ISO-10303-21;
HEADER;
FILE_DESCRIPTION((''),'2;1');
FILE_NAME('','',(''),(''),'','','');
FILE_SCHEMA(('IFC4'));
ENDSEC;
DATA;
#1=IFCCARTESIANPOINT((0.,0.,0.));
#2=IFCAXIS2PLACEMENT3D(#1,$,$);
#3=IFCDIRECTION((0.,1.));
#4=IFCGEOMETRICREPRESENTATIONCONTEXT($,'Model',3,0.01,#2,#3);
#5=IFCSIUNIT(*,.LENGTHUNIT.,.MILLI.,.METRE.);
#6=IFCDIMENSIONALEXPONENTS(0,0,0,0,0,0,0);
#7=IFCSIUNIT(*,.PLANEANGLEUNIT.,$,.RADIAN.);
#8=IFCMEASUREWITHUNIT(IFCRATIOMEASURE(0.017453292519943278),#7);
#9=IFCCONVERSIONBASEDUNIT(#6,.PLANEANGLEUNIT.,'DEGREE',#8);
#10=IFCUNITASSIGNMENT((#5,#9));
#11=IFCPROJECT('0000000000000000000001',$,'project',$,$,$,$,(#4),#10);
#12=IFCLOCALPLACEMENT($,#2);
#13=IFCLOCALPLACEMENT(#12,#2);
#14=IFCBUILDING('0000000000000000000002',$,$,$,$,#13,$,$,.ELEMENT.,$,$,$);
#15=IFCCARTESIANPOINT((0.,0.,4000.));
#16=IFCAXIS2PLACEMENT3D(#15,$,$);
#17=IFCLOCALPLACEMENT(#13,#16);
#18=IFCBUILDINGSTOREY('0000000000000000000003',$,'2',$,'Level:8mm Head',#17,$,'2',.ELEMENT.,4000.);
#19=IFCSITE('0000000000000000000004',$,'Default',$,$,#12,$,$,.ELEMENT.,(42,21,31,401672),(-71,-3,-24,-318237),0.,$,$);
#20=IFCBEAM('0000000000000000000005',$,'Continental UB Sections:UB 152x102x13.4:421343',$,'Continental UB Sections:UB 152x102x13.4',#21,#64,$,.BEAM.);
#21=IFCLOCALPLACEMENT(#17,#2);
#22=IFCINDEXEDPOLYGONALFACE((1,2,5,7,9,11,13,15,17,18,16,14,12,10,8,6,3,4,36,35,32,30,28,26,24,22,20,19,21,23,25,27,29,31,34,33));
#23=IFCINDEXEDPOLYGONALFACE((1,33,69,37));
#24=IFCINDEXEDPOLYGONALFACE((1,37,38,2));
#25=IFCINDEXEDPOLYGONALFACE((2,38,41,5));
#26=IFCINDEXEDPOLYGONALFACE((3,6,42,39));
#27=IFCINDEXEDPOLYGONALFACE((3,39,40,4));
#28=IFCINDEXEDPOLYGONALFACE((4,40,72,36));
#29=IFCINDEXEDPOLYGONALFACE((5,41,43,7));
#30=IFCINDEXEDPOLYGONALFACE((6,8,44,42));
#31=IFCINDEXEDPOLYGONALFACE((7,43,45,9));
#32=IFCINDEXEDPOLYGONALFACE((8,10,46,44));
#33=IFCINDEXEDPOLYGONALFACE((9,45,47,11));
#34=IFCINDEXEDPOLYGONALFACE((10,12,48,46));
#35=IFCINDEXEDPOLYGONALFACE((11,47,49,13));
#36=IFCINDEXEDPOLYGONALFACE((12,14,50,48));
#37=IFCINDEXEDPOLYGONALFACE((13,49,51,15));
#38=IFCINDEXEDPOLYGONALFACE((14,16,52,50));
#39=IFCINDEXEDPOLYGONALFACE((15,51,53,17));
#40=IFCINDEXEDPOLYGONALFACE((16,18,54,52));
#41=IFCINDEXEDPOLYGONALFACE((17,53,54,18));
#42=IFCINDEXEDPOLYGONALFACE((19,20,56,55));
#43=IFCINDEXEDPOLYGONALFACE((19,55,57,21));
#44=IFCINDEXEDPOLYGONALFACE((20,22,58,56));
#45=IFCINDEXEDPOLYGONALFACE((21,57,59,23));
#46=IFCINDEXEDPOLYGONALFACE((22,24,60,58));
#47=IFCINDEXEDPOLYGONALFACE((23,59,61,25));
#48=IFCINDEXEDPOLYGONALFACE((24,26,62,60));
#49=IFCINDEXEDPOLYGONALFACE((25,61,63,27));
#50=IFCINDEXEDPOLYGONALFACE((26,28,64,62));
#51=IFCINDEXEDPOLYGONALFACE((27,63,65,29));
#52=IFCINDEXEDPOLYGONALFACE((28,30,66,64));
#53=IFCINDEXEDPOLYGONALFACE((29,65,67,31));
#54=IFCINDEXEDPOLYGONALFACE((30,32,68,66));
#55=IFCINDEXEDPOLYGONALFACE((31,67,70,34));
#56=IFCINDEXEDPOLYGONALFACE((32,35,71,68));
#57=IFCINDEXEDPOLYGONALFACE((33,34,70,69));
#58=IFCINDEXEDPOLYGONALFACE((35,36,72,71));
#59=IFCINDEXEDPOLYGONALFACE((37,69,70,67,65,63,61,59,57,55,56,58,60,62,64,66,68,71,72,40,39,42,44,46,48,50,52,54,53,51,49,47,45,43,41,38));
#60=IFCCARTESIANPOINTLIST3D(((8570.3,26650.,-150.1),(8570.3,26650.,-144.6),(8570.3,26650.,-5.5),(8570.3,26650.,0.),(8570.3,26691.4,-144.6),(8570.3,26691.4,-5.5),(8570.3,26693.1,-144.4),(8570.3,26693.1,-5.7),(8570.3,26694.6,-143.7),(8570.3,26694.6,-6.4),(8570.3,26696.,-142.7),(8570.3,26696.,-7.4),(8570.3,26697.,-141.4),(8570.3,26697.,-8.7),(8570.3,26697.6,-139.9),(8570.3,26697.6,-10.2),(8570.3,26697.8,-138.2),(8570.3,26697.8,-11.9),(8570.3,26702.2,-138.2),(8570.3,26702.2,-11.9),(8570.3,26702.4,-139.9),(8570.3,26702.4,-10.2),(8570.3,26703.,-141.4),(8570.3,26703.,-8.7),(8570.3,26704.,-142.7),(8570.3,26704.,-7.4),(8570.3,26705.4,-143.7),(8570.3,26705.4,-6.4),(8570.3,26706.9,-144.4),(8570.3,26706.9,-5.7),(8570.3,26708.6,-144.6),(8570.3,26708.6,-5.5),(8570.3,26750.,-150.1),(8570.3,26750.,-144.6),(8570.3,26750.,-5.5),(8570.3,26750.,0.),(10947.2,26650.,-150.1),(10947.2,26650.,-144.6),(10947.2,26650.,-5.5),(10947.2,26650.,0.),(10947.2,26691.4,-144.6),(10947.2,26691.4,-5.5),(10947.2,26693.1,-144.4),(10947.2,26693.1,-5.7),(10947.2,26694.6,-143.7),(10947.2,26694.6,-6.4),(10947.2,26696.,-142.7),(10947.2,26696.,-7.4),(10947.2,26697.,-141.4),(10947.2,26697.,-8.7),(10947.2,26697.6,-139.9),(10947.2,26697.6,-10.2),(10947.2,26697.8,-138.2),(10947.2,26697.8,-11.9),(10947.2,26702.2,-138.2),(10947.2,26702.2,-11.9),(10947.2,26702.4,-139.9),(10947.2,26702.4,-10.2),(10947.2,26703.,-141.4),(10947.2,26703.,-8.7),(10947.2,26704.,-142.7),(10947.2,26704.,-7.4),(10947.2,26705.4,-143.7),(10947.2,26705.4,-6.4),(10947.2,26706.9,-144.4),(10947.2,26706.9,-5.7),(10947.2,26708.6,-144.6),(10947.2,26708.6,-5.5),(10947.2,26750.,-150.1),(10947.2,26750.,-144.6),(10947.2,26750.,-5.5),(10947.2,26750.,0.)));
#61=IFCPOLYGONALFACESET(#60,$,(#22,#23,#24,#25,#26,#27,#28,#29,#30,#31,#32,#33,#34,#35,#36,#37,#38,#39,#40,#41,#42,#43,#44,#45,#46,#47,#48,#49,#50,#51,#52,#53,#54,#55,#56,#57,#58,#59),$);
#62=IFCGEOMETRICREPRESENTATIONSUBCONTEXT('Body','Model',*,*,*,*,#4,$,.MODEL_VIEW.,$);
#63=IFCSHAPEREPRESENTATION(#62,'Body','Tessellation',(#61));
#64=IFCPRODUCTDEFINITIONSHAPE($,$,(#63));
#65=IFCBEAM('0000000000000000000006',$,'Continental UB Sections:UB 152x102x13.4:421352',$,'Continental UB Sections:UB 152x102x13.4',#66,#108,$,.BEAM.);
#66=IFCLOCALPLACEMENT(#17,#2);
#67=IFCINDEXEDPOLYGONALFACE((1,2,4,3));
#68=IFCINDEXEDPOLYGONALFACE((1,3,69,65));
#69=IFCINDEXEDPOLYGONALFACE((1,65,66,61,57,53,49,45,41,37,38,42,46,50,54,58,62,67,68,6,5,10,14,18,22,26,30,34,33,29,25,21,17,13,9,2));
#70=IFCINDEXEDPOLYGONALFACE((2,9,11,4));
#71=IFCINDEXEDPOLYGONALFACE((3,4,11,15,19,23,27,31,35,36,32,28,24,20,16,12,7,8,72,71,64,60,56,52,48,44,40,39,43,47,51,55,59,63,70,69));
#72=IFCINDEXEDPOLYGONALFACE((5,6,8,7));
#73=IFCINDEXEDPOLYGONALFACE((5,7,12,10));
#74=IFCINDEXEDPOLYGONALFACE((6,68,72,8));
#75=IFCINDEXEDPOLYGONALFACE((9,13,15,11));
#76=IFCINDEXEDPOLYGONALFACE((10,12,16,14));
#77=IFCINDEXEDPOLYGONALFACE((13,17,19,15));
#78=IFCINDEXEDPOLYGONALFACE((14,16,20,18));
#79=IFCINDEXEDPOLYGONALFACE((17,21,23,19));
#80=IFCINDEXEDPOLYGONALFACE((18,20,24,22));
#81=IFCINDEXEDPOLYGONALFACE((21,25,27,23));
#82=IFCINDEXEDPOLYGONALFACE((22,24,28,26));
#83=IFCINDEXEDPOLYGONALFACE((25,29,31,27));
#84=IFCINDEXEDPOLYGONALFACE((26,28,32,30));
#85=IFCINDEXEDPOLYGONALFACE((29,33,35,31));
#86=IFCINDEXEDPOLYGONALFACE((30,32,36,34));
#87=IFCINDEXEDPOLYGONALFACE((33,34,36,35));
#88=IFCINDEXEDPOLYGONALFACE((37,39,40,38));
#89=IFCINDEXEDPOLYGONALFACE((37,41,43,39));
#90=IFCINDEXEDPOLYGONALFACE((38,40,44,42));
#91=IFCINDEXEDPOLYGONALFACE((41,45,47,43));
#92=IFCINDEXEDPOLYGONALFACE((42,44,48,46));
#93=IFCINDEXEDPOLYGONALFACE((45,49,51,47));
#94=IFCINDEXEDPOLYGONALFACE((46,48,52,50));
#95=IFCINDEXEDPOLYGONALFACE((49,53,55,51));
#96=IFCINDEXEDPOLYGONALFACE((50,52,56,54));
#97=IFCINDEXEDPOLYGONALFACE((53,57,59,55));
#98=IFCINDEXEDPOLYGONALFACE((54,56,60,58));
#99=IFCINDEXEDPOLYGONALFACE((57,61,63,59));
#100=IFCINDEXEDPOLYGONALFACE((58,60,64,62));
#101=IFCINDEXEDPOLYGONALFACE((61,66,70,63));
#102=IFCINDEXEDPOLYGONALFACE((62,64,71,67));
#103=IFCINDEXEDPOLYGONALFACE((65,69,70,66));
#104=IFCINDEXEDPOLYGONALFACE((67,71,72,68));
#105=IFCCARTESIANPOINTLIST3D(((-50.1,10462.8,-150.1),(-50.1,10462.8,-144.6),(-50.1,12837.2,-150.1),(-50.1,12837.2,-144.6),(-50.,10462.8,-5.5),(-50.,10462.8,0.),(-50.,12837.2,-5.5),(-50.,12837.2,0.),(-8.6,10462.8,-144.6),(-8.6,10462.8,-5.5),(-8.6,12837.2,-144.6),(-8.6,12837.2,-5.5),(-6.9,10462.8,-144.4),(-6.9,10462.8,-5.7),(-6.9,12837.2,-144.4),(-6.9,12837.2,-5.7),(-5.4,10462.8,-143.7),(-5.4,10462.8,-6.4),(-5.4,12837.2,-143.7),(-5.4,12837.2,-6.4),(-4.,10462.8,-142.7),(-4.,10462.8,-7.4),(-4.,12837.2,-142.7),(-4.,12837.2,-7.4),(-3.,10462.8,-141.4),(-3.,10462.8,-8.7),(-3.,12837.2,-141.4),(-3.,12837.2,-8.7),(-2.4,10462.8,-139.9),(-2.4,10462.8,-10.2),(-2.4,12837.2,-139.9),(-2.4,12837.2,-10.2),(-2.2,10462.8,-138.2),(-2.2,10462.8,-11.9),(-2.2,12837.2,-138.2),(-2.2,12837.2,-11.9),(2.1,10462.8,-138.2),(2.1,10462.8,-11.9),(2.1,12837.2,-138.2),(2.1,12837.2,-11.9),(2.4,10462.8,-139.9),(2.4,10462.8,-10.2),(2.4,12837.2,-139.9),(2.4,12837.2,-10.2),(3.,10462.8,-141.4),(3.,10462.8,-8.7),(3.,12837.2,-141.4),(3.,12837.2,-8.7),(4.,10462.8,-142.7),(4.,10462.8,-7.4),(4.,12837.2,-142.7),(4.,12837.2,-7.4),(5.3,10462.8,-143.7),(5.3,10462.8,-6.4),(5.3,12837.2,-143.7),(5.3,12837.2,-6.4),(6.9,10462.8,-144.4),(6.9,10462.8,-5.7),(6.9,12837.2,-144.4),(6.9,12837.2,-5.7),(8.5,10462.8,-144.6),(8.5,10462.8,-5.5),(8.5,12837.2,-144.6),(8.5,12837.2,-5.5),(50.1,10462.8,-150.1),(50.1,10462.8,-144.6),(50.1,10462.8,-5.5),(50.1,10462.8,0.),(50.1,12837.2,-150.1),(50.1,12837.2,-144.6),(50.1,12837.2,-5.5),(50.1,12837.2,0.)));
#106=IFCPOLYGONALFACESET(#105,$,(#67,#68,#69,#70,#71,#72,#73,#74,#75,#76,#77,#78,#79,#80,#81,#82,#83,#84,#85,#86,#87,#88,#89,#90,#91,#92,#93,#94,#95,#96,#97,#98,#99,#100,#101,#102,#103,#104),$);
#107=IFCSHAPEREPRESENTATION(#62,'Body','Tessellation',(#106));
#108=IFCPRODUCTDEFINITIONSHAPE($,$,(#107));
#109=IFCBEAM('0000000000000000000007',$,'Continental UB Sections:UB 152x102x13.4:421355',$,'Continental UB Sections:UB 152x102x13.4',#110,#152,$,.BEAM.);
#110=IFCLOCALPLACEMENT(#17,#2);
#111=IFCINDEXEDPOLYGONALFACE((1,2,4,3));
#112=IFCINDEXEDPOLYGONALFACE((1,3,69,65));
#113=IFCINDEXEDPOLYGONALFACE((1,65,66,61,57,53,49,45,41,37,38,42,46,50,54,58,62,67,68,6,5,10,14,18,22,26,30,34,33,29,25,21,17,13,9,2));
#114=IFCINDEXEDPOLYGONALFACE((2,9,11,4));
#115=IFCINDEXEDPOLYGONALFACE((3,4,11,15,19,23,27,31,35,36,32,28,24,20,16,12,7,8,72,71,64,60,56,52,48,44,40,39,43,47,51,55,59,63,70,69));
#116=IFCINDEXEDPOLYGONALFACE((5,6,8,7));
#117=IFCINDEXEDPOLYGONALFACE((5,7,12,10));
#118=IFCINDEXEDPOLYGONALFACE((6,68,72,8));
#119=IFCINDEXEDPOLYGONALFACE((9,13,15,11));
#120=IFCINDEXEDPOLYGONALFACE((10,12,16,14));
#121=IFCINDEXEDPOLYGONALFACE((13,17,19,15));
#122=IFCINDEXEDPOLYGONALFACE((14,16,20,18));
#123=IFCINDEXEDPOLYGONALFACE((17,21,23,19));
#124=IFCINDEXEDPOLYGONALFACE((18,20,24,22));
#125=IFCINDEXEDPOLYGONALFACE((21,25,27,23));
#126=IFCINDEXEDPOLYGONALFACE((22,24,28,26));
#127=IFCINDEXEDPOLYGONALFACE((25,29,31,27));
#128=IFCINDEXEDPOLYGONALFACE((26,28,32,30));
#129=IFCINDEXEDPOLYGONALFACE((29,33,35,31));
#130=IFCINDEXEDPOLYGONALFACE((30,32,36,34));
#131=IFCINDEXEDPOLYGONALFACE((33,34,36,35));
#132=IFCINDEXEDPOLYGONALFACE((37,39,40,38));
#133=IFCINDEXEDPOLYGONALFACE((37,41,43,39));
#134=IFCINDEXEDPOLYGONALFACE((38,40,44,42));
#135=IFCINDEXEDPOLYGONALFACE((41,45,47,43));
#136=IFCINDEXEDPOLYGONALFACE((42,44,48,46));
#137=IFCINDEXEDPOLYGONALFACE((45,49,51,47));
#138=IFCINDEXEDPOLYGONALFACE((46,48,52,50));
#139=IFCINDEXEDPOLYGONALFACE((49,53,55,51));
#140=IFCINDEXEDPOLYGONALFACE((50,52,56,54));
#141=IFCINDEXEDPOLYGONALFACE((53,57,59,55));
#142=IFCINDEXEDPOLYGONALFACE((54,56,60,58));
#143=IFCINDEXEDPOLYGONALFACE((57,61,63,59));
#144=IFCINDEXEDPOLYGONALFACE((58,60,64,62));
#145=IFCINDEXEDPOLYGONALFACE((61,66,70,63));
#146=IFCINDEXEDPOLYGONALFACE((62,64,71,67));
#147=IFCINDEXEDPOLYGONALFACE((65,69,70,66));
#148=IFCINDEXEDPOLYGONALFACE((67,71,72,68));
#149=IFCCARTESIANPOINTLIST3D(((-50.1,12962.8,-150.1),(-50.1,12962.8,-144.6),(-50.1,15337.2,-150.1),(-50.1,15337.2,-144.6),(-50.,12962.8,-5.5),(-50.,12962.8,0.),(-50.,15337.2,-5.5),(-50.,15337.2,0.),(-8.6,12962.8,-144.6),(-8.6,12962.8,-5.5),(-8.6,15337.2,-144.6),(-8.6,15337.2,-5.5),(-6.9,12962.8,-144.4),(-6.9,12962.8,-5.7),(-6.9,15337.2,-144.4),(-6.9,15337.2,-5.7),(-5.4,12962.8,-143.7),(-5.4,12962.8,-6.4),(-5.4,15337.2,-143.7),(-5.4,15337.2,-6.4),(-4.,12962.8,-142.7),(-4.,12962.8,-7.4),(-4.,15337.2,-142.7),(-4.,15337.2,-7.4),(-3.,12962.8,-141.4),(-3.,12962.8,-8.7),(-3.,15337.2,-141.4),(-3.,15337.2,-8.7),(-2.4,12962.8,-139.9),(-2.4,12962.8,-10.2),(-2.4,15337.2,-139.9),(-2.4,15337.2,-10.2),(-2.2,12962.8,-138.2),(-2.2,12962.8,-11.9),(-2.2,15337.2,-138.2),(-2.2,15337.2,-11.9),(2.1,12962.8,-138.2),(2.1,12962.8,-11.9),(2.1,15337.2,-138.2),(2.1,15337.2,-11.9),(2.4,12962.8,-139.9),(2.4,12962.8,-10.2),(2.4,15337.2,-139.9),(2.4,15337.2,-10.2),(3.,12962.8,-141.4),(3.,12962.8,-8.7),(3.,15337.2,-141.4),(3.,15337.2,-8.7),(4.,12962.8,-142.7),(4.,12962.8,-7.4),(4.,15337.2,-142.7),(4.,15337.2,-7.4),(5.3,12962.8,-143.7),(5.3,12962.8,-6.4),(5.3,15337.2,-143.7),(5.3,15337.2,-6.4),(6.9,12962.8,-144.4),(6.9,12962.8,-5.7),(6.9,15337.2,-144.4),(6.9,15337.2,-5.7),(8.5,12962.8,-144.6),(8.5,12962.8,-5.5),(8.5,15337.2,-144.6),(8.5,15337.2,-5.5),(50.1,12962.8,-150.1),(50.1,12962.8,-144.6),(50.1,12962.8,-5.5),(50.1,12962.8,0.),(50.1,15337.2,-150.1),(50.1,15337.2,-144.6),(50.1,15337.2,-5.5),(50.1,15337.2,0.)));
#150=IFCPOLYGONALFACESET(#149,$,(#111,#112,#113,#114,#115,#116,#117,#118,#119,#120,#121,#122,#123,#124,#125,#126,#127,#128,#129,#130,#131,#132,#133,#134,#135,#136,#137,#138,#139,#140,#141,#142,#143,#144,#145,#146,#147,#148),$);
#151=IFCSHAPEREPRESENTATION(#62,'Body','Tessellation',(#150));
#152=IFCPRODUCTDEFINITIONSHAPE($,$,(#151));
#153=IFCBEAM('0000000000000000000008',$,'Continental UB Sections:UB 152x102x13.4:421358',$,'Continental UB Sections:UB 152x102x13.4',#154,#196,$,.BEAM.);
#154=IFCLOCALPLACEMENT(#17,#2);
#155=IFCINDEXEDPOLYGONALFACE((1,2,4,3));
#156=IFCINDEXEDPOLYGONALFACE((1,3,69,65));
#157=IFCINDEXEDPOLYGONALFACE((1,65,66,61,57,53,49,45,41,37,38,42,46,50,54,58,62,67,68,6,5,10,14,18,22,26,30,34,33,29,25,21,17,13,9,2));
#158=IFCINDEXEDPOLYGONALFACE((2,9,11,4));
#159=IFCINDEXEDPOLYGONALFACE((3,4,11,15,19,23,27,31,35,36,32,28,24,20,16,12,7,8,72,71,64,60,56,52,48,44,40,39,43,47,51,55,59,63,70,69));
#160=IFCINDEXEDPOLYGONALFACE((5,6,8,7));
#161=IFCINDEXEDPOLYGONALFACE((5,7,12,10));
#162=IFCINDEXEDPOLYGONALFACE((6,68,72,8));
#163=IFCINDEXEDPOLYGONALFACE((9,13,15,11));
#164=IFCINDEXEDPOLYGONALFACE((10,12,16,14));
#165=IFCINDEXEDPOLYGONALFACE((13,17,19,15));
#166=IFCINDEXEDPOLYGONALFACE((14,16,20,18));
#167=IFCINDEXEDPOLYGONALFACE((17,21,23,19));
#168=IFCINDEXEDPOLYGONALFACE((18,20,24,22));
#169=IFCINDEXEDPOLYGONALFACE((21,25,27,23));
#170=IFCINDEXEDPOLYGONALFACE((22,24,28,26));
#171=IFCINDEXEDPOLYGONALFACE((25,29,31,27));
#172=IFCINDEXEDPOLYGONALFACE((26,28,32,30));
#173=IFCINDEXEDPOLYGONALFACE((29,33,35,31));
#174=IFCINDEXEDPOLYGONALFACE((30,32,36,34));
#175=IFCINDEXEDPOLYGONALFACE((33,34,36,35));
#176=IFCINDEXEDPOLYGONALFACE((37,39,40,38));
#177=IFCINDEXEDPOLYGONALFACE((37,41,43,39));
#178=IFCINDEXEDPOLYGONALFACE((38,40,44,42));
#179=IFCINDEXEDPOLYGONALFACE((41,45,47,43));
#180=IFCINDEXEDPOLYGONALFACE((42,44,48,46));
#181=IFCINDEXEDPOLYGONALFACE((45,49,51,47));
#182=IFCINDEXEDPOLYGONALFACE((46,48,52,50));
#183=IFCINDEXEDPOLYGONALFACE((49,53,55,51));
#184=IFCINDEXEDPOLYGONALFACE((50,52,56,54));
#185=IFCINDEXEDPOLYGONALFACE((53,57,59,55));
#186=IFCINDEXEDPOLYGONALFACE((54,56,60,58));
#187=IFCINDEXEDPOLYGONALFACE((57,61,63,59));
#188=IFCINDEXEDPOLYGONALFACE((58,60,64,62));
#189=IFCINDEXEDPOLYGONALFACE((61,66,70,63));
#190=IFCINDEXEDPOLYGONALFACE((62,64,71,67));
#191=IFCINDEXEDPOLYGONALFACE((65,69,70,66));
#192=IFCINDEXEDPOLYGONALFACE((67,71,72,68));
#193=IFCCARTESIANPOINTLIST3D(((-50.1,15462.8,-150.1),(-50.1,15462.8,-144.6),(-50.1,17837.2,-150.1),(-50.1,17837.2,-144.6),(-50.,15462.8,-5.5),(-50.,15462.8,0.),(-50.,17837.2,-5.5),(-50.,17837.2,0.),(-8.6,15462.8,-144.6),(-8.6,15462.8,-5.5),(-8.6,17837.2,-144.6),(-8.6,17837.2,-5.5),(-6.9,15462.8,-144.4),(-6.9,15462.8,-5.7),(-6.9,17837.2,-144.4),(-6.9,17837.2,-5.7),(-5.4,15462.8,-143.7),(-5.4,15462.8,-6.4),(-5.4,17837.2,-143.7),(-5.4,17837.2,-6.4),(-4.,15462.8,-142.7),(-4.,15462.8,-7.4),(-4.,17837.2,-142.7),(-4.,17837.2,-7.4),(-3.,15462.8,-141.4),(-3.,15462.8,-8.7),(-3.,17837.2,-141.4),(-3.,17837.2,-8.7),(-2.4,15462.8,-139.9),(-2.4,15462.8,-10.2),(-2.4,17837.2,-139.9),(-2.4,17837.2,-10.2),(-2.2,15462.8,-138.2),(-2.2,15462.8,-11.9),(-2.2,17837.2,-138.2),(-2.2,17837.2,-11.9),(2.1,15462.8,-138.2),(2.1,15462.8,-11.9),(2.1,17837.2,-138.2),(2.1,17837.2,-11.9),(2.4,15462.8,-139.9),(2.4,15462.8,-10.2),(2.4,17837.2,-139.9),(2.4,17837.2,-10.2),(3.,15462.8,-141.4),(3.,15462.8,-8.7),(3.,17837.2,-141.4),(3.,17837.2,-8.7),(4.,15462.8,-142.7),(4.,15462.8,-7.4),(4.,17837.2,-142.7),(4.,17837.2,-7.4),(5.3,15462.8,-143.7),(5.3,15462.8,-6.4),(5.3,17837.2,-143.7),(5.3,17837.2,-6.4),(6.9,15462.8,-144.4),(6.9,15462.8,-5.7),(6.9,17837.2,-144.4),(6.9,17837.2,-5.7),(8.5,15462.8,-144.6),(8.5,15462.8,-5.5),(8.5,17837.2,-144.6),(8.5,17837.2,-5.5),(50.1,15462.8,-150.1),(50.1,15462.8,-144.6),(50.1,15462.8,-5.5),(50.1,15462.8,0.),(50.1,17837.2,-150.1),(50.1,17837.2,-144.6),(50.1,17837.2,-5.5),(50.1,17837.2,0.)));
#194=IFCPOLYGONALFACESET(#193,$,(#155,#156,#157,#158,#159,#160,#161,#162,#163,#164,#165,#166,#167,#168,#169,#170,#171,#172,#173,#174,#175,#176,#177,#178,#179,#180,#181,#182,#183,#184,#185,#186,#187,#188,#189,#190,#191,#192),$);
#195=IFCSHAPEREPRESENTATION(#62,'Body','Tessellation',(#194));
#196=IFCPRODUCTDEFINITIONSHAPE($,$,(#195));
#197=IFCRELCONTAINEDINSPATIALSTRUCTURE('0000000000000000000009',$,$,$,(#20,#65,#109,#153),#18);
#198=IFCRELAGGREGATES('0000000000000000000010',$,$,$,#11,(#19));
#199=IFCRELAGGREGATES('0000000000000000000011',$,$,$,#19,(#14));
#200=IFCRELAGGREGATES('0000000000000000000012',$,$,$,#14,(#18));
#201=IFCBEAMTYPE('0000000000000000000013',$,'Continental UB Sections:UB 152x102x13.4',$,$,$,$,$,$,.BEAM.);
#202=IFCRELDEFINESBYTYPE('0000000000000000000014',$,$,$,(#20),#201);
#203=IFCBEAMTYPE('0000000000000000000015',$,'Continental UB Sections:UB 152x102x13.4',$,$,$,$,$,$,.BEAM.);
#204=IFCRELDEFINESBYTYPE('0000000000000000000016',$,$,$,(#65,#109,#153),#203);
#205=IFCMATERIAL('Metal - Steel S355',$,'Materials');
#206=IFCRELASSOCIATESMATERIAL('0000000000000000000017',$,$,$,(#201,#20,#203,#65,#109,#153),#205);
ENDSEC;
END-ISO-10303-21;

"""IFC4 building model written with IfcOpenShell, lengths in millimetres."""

from ifc_helpers import new_model, entity, si_unit, converted_unit, direction, frame, origin, place, context, subcontext, project, spatial, line, arc, indexed_curve, outline, extrude, source, transform, mapped, material, type_object, type_shapes, element, save


model = new_model("IFC4")

# Units and contexts
model_context = context("Model", 3, precision=0.01, world=origin(), true_north=direction((0.0, 1.0)))
body_context = subcontext(model_context, "Body", "Model", "MODEL_VIEW")
ifc_project = project(units=[si_unit("LENGTHUNIT", "METRE", prefix="MILLI"), converted_unit("PLANEANGLEUNIT", "DEGREE", entity("IfcRatioMeasure", 0.017453292519943278), si_unit("PLANEANGLEUNIT", "RADIAN"), dimensions=[0, 0, 0, 0, 0, 0, 0])], contexts=[model_context])

# Site, building, storey
site_placement = place(None, origin())
site = spatial("IfcSite", under=ifc_project, at=site_placement, Name="Default", CompositionType="ELEMENT", RefLatitude=(42, 21, 31, 401672), RefLongitude=(-71, -3, -24, -318237), RefElevation=0.0)
building_placement = place(site_placement, origin())
building = spatial("IfcBuilding", under=site, at=building_placement, CompositionType="ELEMENT")
storey_placement = place(building_placement, frame((0.0, 0.0, 4000.0)))
storey = spatial("IfcBuildingStorey", under=building, at=storey_placement, Name="2", ObjectType="Level:8mm Head", LongName="2", CompositionType="ELEMENT", Elevation=4000.0)

# Beams
ifc_material_1 = material(Name="Metal - Steel S355", Category="Materials")
beam_type_1 = type_object("IfcBeamType", Name="Continental UB Sections:UB 152x102x13.4", PredefinedType="BEAM", material=ifc_material_1)
shared_shape_1 = source(origin(), body_context, "Body", "SweptSolid", [
    extrude(outline(indexed_curve([(-75.0, -50.1), (-69.6, -50.1), (-69.6, -8.5), (-67.7, -4.0), (-63.2, -2.1), (63.1, -2.1), (67.7, -4.0), (69.5, -8.5), (69.5, -50.1), (75.1, -50.1), (75.1, 50.1), (69.5, 50.1), (69.5, 8.6), (67.7, 4.0), (63.1, 2.2), (-63.2, 2.2), (-67.7, 4.0), (-69.6, 8.6), (-69.6, 50.0), (-75.0, 50.0)], segments=[line(1, 2, 3), arc(3, 4, 5), line(5, 6), arc(6, 7, 8), line(8, 9, 10, 11, 12, 13), arc(13, 14, 15), line(15, 16), arc(16, 17, 18), line(18, 19, 20, 1)], self_intersect=False)), frame((-1188.4, 0.0, 0.0), z_axis=(1.0, 0.0, 0.0), x_axis=(0.0, 0.0, -1.0)), (0.0, 0.0, 1.0), 2376.9),
])
type_shapes(beam_type_1, [shared_shape_1])
for number, where, name in (
    (1, (9758.8, 26700.0, -75.1), "Continental UB Sections:UB 152x102x13.4:421343"),
):
    element("IfcBeam", number, at=place(storey_placement, frame(where)), inside=storey, type_object=beam_type_1, material=ifc_material_1, Name=name, ObjectType="Continental UB Sections:UB 152x102x13.4", PredefinedType="BEAM", context=body_context, shape_type="MappedRepresentation", body=[
        mapped(shared_shape_1, transform((0.0, 0.0, 0.0), scale=1.0)),
    ])
beam_type_2 = type_object("IfcBeamType", Name="Continental UB Sections:UB 152x102x13.4", PredefinedType="BEAM", material=ifc_material_1)
shared_shape_2 = source(origin(), body_context, "Body", "SweptSolid", [
    extrude(outline(indexed_curve([(-75.0, -50.1), (-69.6, -50.1), (-69.6, -8.5), (-67.7, -4.0), (-63.2, -2.1), (63.1, -2.1), (67.7, -4.0), (69.5, -8.5), (69.5, -50.1), (75.1, -50.1), (75.1, 50.1), (69.5, 50.1), (69.5, 8.6), (67.7, 4.0), (63.1, 2.2), (-63.2, 2.2), (-67.7, 4.0), (-69.6, 8.6), (-69.6, 50.0), (-75.0, 50.0)], segments=[line(1, 2, 3), arc(3, 4, 5), line(5, 6), arc(6, 7, 8), line(8, 9, 10, 11, 12, 13), arc(13, 14, 15), line(15, 16), arc(16, 17, 18), line(18, 19, 20, 1)], self_intersect=False)), frame((-1187.2, 0.0, 0.0), z_axis=(1.0, 0.0, 0.0), x_axis=(0.0, 0.0, -1.0)), (0.0, 0.0, 1.0), 2374.4),
])
type_shapes(beam_type_2, [shared_shape_2])
for number, where, z_axis, x_axis, name in (
    (2, (0.0, 11650.0, -75.1), (0.0, 0.0, 1.0), (0.0, 1.0, 0.0), "Continental UB Sections:UB 152x102x13.4:421352"),
    (3, (0.0, 14150.0, -75.1), (0.0, 0.0, 1.0), (0.0, 1.0, 0.0), "Continental UB Sections:UB 152x102x13.4:421355"),
    (4, (0.0, 16650.0, -75.1), (0.0, 0.0, 1.0), (0.0, 1.0, 0.0), "Continental UB Sections:UB 152x102x13.4:421358"),
):
    element("IfcBeam", number, at=place(storey_placement, frame(where, z_axis=z_axis, x_axis=x_axis)), inside=storey, type_object=beam_type_2, material=ifc_material_1, Name=name, ObjectType="Continental UB Sections:UB 152x102x13.4", PredefinedType="BEAM", context=body_context, shape_type="MappedRepresentation", body=[
        mapped(shared_shape_2, transform((0.0, 0.0, 0.0), scale=1.0)),
    ])

save(model, "model.ifc")
